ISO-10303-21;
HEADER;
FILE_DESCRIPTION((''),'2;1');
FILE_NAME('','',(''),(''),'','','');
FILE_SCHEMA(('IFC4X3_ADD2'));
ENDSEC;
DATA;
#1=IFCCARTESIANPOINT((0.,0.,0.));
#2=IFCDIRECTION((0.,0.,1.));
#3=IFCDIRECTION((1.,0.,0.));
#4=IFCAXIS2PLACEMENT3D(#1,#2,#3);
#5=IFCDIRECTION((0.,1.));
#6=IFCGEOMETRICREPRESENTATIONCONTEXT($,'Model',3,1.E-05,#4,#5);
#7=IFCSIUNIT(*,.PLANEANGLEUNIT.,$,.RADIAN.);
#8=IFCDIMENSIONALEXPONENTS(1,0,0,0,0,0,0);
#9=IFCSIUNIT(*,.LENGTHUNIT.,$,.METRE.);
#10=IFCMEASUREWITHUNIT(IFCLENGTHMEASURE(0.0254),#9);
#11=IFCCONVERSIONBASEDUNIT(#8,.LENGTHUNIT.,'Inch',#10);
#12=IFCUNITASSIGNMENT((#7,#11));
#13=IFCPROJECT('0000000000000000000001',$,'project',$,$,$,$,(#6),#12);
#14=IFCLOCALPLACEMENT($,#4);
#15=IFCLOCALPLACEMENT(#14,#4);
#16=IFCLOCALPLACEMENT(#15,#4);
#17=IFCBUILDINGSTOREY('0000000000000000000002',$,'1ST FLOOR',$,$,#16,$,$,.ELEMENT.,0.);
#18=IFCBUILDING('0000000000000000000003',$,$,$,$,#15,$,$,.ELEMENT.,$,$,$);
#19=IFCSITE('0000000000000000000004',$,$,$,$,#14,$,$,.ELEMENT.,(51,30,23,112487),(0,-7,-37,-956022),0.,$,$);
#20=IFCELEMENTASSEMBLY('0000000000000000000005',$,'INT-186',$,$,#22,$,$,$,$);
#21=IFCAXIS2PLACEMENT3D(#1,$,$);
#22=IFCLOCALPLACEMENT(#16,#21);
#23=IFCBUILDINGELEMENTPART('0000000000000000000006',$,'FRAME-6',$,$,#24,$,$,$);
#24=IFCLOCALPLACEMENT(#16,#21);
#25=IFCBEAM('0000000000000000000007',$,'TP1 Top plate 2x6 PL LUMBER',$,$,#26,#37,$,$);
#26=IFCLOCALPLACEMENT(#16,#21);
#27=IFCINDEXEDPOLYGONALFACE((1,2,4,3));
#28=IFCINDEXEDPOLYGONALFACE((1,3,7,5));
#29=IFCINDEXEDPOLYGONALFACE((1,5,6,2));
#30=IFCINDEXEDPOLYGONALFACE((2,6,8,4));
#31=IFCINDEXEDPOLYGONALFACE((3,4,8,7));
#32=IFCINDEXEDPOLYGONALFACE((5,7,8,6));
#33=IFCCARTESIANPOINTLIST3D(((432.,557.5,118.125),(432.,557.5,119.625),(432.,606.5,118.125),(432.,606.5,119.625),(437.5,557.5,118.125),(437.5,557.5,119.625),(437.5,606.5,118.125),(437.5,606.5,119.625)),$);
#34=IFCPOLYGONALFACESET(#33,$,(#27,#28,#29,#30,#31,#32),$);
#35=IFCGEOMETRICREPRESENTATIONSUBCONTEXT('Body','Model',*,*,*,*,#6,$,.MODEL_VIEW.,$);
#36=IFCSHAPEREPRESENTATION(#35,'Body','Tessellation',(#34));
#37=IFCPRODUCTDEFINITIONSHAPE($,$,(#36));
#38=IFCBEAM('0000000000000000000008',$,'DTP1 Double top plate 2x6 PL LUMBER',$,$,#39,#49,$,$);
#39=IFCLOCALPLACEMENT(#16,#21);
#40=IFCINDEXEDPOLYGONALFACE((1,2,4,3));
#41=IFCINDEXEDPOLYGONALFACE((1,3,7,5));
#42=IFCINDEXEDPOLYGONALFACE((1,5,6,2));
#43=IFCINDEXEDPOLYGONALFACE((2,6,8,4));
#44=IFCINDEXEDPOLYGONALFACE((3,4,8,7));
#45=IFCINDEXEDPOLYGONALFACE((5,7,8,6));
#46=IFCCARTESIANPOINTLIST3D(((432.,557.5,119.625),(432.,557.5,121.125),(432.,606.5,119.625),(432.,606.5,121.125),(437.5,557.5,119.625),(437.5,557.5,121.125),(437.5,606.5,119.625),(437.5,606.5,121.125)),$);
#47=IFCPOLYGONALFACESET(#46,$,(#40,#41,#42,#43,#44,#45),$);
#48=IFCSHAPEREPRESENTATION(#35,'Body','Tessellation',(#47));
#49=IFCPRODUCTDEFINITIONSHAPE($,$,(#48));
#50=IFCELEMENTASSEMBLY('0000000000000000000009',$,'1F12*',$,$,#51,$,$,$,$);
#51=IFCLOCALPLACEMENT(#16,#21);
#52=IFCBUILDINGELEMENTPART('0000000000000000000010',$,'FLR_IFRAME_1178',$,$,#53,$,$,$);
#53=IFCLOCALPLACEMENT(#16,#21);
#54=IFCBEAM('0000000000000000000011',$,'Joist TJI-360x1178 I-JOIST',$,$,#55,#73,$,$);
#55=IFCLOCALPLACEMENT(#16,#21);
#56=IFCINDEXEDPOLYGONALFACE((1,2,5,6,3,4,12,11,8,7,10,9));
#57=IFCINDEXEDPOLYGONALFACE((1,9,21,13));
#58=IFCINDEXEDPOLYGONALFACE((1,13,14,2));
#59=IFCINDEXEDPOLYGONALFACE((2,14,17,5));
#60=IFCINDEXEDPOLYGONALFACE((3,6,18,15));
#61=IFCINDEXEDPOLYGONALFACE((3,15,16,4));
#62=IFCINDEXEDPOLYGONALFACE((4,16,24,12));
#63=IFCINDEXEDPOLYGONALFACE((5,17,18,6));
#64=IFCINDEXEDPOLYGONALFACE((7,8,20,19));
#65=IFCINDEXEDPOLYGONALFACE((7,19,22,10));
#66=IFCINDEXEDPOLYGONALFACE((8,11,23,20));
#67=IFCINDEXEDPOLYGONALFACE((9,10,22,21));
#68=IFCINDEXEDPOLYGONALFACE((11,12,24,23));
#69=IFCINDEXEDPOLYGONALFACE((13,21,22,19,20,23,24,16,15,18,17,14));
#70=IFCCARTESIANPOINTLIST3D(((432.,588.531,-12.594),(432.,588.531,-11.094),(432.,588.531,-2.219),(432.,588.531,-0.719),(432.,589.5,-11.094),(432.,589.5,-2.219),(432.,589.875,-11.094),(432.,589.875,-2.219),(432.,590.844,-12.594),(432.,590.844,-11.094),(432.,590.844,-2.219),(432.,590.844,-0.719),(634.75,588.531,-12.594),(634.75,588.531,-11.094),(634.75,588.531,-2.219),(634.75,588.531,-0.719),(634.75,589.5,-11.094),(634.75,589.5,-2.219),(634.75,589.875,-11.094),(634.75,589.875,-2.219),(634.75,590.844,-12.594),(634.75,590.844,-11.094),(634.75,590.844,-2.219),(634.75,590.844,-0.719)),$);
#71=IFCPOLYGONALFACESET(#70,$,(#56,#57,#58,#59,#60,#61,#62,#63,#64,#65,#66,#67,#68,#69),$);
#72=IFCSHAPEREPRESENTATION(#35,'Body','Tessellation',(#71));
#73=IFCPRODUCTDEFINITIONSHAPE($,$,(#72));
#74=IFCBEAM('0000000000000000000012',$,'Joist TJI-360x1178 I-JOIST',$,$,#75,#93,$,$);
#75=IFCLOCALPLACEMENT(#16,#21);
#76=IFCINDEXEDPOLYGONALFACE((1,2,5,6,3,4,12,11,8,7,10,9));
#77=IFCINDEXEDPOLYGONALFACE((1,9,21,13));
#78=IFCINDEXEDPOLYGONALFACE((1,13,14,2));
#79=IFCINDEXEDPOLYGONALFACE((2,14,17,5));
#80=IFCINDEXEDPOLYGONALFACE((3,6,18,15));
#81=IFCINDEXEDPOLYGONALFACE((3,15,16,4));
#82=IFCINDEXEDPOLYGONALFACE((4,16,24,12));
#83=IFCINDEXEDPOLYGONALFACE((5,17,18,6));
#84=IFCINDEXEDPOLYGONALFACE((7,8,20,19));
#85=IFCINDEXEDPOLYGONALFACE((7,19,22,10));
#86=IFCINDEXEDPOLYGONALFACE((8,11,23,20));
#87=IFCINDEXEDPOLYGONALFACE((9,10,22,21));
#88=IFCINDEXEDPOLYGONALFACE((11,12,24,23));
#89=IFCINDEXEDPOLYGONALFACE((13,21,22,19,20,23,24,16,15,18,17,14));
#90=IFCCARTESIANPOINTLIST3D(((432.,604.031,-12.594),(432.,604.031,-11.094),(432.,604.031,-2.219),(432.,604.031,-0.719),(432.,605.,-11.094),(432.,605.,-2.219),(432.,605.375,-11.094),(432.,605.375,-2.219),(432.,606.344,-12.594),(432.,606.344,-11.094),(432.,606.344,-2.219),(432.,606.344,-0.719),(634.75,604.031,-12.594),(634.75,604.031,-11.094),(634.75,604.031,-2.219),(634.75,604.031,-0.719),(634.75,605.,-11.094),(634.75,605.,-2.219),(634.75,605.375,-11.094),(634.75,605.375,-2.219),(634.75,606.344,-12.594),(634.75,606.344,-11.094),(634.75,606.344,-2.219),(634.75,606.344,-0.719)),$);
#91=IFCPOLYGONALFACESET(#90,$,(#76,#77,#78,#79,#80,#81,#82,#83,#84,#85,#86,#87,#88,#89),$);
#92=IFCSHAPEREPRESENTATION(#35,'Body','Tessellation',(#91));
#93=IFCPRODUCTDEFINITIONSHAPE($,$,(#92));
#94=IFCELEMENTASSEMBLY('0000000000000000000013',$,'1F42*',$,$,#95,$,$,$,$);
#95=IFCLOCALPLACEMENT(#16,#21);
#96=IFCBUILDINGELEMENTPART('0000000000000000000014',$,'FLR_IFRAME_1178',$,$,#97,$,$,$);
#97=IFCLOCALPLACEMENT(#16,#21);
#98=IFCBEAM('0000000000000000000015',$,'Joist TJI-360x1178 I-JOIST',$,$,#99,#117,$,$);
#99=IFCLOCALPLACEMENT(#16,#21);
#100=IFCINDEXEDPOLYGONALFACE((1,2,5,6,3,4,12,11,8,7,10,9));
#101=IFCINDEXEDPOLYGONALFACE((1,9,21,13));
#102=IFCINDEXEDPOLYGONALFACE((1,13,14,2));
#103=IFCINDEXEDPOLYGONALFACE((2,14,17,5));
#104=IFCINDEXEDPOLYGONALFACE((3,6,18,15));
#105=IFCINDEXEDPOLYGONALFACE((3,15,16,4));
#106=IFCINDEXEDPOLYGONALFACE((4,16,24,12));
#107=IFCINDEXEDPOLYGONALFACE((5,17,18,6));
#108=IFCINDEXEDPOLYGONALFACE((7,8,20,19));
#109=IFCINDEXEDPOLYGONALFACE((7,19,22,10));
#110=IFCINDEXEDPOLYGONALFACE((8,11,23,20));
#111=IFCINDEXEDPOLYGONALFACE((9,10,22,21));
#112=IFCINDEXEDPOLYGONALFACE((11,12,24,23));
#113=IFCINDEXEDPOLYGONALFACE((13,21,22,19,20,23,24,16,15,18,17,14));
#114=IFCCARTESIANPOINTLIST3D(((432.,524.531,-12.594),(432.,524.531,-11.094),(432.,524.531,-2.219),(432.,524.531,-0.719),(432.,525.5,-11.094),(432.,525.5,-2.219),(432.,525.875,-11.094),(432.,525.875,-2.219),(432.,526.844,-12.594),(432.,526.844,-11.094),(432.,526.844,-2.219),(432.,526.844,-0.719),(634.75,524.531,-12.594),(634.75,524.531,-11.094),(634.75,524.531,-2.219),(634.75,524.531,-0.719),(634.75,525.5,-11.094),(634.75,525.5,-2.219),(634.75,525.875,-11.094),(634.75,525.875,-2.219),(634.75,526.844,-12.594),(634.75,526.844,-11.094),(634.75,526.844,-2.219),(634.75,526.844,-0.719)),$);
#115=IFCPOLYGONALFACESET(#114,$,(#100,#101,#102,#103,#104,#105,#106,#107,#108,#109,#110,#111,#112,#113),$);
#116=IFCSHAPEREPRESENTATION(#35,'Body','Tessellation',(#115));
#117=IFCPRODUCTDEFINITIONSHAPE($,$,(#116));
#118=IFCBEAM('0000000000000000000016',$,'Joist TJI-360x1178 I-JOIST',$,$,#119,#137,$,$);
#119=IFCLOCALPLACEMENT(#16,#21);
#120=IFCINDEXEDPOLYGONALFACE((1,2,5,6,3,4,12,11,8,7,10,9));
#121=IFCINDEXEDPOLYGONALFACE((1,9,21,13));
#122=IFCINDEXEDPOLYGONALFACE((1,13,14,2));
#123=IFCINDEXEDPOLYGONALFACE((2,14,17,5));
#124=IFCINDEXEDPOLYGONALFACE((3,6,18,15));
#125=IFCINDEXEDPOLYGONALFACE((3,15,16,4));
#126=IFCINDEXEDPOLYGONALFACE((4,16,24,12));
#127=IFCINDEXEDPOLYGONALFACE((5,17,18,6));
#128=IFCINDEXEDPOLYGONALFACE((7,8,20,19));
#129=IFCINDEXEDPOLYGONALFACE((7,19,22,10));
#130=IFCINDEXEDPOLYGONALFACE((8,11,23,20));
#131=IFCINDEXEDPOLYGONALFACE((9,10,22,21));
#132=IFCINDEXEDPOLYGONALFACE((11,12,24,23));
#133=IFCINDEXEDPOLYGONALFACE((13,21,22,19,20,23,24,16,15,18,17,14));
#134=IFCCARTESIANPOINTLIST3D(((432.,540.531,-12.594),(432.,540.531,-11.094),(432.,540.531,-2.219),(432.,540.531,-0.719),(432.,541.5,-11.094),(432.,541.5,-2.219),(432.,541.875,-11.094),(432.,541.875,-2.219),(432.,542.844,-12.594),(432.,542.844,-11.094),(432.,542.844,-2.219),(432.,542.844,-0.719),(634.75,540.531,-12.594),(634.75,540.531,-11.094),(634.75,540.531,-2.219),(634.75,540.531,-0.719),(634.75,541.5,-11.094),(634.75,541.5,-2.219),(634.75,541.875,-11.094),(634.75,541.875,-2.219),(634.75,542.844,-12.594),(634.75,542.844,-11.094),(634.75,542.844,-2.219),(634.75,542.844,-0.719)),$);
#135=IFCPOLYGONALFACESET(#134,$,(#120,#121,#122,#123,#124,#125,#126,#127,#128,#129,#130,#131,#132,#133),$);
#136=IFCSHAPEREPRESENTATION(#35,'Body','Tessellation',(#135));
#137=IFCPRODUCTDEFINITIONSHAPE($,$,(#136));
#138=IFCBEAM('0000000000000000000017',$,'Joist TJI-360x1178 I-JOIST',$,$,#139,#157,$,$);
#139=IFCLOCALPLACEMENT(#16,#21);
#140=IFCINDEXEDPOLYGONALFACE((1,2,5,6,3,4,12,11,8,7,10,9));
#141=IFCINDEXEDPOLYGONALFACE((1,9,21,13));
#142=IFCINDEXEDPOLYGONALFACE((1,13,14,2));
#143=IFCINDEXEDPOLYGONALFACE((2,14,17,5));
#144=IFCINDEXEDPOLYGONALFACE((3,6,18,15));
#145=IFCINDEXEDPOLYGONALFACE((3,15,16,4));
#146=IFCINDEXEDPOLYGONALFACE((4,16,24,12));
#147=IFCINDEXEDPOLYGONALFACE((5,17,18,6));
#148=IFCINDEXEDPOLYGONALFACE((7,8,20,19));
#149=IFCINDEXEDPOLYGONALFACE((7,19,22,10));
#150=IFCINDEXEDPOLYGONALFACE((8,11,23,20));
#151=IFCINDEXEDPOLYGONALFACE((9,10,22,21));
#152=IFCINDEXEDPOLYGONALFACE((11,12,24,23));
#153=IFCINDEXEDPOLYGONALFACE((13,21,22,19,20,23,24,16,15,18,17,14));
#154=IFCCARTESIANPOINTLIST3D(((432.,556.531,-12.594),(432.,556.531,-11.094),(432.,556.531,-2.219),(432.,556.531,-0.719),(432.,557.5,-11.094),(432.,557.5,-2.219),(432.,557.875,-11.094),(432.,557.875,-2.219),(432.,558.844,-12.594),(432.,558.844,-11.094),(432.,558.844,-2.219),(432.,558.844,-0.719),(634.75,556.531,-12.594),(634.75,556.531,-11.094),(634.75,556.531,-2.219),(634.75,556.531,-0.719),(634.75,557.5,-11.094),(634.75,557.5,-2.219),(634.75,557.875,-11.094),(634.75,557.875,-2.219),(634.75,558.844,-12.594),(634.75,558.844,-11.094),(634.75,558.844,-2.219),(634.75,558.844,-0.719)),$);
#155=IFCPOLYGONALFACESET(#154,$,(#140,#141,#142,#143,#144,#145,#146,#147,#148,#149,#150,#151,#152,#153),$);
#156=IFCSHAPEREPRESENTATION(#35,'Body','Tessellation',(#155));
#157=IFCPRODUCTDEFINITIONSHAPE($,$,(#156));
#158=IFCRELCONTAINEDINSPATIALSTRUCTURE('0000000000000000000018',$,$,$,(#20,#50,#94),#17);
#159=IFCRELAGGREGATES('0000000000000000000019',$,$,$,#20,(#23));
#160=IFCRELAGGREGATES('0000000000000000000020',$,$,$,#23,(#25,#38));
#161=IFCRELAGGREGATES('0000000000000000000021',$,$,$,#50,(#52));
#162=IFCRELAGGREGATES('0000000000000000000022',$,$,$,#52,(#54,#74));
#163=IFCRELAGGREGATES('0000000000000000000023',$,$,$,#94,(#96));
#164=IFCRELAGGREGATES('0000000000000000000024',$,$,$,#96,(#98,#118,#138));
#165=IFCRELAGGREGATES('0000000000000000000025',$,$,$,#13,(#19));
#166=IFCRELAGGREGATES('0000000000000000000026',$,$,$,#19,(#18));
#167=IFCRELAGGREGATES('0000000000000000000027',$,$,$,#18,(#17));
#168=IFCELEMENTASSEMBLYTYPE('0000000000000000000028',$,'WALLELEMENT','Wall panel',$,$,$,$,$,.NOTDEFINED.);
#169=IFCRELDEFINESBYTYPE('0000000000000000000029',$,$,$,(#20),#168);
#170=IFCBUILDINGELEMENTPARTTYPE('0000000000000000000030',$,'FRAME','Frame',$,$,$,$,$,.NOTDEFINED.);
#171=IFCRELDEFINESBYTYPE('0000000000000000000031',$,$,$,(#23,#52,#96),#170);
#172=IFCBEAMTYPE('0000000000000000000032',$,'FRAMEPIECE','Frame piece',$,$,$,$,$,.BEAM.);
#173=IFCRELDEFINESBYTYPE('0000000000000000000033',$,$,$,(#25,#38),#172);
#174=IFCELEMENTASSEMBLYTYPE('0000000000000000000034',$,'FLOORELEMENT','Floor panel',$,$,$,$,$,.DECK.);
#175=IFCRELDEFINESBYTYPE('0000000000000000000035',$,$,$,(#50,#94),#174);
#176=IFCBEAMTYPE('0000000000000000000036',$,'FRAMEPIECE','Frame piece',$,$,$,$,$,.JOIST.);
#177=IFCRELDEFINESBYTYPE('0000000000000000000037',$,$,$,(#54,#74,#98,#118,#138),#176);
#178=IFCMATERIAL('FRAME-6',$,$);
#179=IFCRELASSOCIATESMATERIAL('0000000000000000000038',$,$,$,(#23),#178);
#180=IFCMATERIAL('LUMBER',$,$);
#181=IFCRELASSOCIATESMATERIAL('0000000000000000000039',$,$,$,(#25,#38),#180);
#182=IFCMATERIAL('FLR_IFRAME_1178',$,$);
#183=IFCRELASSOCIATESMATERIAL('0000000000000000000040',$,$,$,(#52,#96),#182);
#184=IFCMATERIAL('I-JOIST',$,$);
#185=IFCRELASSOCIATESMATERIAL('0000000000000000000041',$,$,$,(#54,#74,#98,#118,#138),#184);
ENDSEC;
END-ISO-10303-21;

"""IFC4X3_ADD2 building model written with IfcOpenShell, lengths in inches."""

from ifc_helpers import new_model, entity, si_unit, converted_unit, direction, frame, origin_with_axes, origin_2d_with_axis, place, context, subcontext, project, spatial, rectangle, i_section, extrude, material, type_object, element, aggregate, save


model = new_model("IFC4X3_ADD2")

# Units and contexts
model_context = context("Model", 3, precision=1e-05, world=origin_with_axes(), true_north=direction((0.0, 1.0)))
body_context = subcontext(model_context, "Body", "Model", "MODEL_VIEW")
ifc_project = project(units=[si_unit("PLANEANGLEUNIT", "RADIAN"), converted_unit("LENGTHUNIT", "Inch", entity("IfcLengthMeasure", 0.0254), si_unit("LENGTHUNIT", "METRE"), dimensions=[1, 0, 0, 0, 0, 0, 0])], contexts=[model_context])

# Site, building, storey
site_placement = place(None, origin_with_axes())
site = spatial("IfcSite", under=ifc_project, at=site_placement, CompositionType="ELEMENT", RefLatitude=(51, 30, 23, 112487), RefLongitude=(0, -7, -37, -956022), RefElevation=0.0)
building_placement = place(site_placement, origin_with_axes())
building = spatial("IfcBuilding", under=site, at=building_placement, CompositionType="ELEMENT")
storey_placement = place(building_placement, origin_with_axes())
storey = spatial("IfcBuildingStorey", under=building, at=storey_placement, Name="1ST FLOOR", CompositionType="ELEMENT", Elevation=0.0)

# Shared definitions
element_assembly_type_1 = type_object("IfcElementAssemblyType", Name="WALLELEMENT", Description="Wall panel", PredefinedType="NOTDEFINED")
building_element_part_type = type_object("IfcBuildingElementPartType", Name="FRAME", Description="Frame", PredefinedType="NOTDEFINED")
ifc_material_1 = material(Name="LUMBER")
ifc_material_2 = material(Name="FRAME-6")

# Element assembly, building element part
assembly_1_placement = place(storey_placement, origin_with_axes())
assembly_1 = element("IfcElementAssembly", 1, at=assembly_1_placement, inside=storey, type_object=element_assembly_type_1, Name="INT-186")
building_element_part_1_placement = place(storey_placement, origin_with_axes())
building_element_part_1 = element("IfcBuildingElementPart", 2, at=building_element_part_1_placement, type_object=building_element_part_type, material=ifc_material_2, Name="FRAME-6")
aggregate(assembly_1, [building_element_part_1])

# Beams
beam_type_1 = type_object("IfcBeamType", Name="FRAMEPIECE", Description="Frame piece", PredefinedType="BEAM")
beam_1_placement = place(storey_placement, frame((434.75, 606.5, 118.875), z_axis=(0.0, -1.0, 0.0), x_axis=(0.0, 0.0, -1.0)))
beam_1 = element("IfcBeam", 3, at=beam_1_placement, type_object=beam_type_1, material=ifc_material_1, Name="TP1 Top plate 2x6 PL LUMBER", context=body_context, shape_type="SweptSolid", body=[
    extrude(rectangle(XDim=1.5, YDim=5.5, at=origin_2d_with_axis()), origin_with_axes(), (0.0, 0.0, 1.0), 49.0),
])
beam_2_placement = place(storey_placement, frame((434.75, 606.5, 120.375), z_axis=(0.0, -1.0, 0.0), x_axis=(0.0, 0.0, -1.0)))
beam_2 = element("IfcBeam", 4, at=beam_2_placement, type_object=beam_type_1, material=ifc_material_1, Name="DTP1 Double top plate 2x6 PL LUMBER", context=body_context, shape_type="SweptSolid", body=[
    extrude(rectangle(XDim=1.5, YDim=5.5, at=origin_2d_with_axis()), origin_with_axes(), (0.0, 0.0, 1.0), 49.0),
])
aggregate(building_element_part_1, [beam_1, beam_2])

# Element assemblies, building element parts, beams
element_assembly_type_2 = type_object("IfcElementAssemblyType", Name="FLOORELEMENT", Description="Floor panel", PredefinedType="DECK")
assembly_2_placement = place(storey_placement, origin_with_axes())
assembly_2 = element("IfcElementAssembly", 5, at=assembly_2_placement, inside=storey, type_object=element_assembly_type_2, Name="1F12*")
ifc_material_3 = material(Name="FLR_IFRAME_1178")
building_element_part_2_placement = place(storey_placement, origin_with_axes())
building_element_part_2 = element("IfcBuildingElementPart", 6, at=building_element_part_2_placement, type_object=building_element_part_type, material=ifc_material_3, Name="FLR_IFRAME_1178")
aggregate(assembly_2, [building_element_part_2])
ifc_material_4 = material(Name="I-JOIST")
beam_type_2 = type_object("IfcBeamType", Name="FRAMEPIECE", Description="Frame piece", PredefinedType="JOIST")
beam_3_placement = place(storey_placement, frame((432.0, 589.688, -6.656), z_axis=(1.0, 0.0, 0.0), x_axis=(0.0, 1.0, 0.0)))
beam_3 = element("IfcBeam", 7, at=beam_3_placement, type_object=beam_type_2, material=ifc_material_4, Name="Joist TJI-360x1178 I-JOIST", context=body_context, shape_type="SweptSolid", body=[
    extrude(i_section(OverallWidth=2.313, OverallDepth=11.875, WebThickness=0.375, FlangeThickness=1.5, at=origin_2d_with_axis()), origin_with_axes(), (0.0, 0.0, 1.0), 202.75),
])
beam_4_placement = place(storey_placement, frame((432.0, 605.188, -6.656), z_axis=(1.0, 0.0, 0.0), x_axis=(0.0, 1.0, 0.0)))
beam_4 = element("IfcBeam", 8, at=beam_4_placement, type_object=beam_type_2, material=ifc_material_4, Name="Joist TJI-360x1178 I-JOIST", context=body_context, shape_type="SweptSolid", body=[
    extrude(i_section(OverallWidth=2.313, OverallDepth=11.875, WebThickness=0.375, FlangeThickness=1.5, at=origin_2d_with_axis()), origin_with_axes(), (0.0, 0.0, 1.0), 202.75),
])
aggregate(building_element_part_2, [beam_3, beam_4])
assembly_3_placement = place(storey_placement, origin_with_axes())
assembly_3 = element("IfcElementAssembly", 9, at=assembly_3_placement, inside=storey, type_object=element_assembly_type_2, Name="1F42*")
building_element_part_3_placement = place(storey_placement, origin_with_axes())
building_element_part_3 = element("IfcBuildingElementPart", 10, at=building_element_part_3_placement, type_object=building_element_part_type, material=ifc_material_3, Name="FLR_IFRAME_1178")
aggregate(assembly_3, [building_element_part_3])
beam_5_placement = place(storey_placement, frame((432.0, 525.688, -6.656), z_axis=(1.0, 0.0, 0.0), x_axis=(0.0, 1.0, 0.0)))
beam_5 = element("IfcBeam", 11, at=beam_5_placement, type_object=beam_type_2, material=ifc_material_4, Name="Joist TJI-360x1178 I-JOIST", context=body_context, shape_type="SweptSolid", body=[
    extrude(i_section(OverallWidth=2.313, OverallDepth=11.875, WebThickness=0.375, FlangeThickness=1.5, at=origin_2d_with_axis()), origin_with_axes(), (0.0, 0.0, 1.0), 202.75),
])
beam_6_placement = place(storey_placement, frame((432.0, 541.688, -6.656), z_axis=(1.0, 0.0, 0.0), x_axis=(0.0, 1.0, 0.0)))
beam_6 = element("IfcBeam", 12, at=beam_6_placement, type_object=beam_type_2, material=ifc_material_4, Name="Joist TJI-360x1178 I-JOIST", context=body_context, shape_type="SweptSolid", body=[
    extrude(i_section(OverallWidth=2.313, OverallDepth=11.875, WebThickness=0.375, FlangeThickness=1.5, at=origin_2d_with_axis()), origin_with_axes(), (0.0, 0.0, 1.0), 202.75),
])
beam_7_placement = place(storey_placement, frame((432.0, 557.688, -6.656), z_axis=(1.0, 0.0, 0.0), x_axis=(0.0, 1.0, 0.0)))
beam_7 = element("IfcBeam", 13, at=beam_7_placement, type_object=beam_type_2, material=ifc_material_4, Name="Joist TJI-360x1178 I-JOIST", context=body_context, shape_type="SweptSolid", body=[
    extrude(i_section(OverallWidth=2.313, OverallDepth=11.875, WebThickness=0.375, FlangeThickness=1.5, at=origin_2d_with_axis()), origin_with_axes(), (0.0, 0.0, 1.0), 202.75),
])
aggregate(building_element_part_3, [beam_5, beam_6, beam_7])

save(model, "model.ifc")
